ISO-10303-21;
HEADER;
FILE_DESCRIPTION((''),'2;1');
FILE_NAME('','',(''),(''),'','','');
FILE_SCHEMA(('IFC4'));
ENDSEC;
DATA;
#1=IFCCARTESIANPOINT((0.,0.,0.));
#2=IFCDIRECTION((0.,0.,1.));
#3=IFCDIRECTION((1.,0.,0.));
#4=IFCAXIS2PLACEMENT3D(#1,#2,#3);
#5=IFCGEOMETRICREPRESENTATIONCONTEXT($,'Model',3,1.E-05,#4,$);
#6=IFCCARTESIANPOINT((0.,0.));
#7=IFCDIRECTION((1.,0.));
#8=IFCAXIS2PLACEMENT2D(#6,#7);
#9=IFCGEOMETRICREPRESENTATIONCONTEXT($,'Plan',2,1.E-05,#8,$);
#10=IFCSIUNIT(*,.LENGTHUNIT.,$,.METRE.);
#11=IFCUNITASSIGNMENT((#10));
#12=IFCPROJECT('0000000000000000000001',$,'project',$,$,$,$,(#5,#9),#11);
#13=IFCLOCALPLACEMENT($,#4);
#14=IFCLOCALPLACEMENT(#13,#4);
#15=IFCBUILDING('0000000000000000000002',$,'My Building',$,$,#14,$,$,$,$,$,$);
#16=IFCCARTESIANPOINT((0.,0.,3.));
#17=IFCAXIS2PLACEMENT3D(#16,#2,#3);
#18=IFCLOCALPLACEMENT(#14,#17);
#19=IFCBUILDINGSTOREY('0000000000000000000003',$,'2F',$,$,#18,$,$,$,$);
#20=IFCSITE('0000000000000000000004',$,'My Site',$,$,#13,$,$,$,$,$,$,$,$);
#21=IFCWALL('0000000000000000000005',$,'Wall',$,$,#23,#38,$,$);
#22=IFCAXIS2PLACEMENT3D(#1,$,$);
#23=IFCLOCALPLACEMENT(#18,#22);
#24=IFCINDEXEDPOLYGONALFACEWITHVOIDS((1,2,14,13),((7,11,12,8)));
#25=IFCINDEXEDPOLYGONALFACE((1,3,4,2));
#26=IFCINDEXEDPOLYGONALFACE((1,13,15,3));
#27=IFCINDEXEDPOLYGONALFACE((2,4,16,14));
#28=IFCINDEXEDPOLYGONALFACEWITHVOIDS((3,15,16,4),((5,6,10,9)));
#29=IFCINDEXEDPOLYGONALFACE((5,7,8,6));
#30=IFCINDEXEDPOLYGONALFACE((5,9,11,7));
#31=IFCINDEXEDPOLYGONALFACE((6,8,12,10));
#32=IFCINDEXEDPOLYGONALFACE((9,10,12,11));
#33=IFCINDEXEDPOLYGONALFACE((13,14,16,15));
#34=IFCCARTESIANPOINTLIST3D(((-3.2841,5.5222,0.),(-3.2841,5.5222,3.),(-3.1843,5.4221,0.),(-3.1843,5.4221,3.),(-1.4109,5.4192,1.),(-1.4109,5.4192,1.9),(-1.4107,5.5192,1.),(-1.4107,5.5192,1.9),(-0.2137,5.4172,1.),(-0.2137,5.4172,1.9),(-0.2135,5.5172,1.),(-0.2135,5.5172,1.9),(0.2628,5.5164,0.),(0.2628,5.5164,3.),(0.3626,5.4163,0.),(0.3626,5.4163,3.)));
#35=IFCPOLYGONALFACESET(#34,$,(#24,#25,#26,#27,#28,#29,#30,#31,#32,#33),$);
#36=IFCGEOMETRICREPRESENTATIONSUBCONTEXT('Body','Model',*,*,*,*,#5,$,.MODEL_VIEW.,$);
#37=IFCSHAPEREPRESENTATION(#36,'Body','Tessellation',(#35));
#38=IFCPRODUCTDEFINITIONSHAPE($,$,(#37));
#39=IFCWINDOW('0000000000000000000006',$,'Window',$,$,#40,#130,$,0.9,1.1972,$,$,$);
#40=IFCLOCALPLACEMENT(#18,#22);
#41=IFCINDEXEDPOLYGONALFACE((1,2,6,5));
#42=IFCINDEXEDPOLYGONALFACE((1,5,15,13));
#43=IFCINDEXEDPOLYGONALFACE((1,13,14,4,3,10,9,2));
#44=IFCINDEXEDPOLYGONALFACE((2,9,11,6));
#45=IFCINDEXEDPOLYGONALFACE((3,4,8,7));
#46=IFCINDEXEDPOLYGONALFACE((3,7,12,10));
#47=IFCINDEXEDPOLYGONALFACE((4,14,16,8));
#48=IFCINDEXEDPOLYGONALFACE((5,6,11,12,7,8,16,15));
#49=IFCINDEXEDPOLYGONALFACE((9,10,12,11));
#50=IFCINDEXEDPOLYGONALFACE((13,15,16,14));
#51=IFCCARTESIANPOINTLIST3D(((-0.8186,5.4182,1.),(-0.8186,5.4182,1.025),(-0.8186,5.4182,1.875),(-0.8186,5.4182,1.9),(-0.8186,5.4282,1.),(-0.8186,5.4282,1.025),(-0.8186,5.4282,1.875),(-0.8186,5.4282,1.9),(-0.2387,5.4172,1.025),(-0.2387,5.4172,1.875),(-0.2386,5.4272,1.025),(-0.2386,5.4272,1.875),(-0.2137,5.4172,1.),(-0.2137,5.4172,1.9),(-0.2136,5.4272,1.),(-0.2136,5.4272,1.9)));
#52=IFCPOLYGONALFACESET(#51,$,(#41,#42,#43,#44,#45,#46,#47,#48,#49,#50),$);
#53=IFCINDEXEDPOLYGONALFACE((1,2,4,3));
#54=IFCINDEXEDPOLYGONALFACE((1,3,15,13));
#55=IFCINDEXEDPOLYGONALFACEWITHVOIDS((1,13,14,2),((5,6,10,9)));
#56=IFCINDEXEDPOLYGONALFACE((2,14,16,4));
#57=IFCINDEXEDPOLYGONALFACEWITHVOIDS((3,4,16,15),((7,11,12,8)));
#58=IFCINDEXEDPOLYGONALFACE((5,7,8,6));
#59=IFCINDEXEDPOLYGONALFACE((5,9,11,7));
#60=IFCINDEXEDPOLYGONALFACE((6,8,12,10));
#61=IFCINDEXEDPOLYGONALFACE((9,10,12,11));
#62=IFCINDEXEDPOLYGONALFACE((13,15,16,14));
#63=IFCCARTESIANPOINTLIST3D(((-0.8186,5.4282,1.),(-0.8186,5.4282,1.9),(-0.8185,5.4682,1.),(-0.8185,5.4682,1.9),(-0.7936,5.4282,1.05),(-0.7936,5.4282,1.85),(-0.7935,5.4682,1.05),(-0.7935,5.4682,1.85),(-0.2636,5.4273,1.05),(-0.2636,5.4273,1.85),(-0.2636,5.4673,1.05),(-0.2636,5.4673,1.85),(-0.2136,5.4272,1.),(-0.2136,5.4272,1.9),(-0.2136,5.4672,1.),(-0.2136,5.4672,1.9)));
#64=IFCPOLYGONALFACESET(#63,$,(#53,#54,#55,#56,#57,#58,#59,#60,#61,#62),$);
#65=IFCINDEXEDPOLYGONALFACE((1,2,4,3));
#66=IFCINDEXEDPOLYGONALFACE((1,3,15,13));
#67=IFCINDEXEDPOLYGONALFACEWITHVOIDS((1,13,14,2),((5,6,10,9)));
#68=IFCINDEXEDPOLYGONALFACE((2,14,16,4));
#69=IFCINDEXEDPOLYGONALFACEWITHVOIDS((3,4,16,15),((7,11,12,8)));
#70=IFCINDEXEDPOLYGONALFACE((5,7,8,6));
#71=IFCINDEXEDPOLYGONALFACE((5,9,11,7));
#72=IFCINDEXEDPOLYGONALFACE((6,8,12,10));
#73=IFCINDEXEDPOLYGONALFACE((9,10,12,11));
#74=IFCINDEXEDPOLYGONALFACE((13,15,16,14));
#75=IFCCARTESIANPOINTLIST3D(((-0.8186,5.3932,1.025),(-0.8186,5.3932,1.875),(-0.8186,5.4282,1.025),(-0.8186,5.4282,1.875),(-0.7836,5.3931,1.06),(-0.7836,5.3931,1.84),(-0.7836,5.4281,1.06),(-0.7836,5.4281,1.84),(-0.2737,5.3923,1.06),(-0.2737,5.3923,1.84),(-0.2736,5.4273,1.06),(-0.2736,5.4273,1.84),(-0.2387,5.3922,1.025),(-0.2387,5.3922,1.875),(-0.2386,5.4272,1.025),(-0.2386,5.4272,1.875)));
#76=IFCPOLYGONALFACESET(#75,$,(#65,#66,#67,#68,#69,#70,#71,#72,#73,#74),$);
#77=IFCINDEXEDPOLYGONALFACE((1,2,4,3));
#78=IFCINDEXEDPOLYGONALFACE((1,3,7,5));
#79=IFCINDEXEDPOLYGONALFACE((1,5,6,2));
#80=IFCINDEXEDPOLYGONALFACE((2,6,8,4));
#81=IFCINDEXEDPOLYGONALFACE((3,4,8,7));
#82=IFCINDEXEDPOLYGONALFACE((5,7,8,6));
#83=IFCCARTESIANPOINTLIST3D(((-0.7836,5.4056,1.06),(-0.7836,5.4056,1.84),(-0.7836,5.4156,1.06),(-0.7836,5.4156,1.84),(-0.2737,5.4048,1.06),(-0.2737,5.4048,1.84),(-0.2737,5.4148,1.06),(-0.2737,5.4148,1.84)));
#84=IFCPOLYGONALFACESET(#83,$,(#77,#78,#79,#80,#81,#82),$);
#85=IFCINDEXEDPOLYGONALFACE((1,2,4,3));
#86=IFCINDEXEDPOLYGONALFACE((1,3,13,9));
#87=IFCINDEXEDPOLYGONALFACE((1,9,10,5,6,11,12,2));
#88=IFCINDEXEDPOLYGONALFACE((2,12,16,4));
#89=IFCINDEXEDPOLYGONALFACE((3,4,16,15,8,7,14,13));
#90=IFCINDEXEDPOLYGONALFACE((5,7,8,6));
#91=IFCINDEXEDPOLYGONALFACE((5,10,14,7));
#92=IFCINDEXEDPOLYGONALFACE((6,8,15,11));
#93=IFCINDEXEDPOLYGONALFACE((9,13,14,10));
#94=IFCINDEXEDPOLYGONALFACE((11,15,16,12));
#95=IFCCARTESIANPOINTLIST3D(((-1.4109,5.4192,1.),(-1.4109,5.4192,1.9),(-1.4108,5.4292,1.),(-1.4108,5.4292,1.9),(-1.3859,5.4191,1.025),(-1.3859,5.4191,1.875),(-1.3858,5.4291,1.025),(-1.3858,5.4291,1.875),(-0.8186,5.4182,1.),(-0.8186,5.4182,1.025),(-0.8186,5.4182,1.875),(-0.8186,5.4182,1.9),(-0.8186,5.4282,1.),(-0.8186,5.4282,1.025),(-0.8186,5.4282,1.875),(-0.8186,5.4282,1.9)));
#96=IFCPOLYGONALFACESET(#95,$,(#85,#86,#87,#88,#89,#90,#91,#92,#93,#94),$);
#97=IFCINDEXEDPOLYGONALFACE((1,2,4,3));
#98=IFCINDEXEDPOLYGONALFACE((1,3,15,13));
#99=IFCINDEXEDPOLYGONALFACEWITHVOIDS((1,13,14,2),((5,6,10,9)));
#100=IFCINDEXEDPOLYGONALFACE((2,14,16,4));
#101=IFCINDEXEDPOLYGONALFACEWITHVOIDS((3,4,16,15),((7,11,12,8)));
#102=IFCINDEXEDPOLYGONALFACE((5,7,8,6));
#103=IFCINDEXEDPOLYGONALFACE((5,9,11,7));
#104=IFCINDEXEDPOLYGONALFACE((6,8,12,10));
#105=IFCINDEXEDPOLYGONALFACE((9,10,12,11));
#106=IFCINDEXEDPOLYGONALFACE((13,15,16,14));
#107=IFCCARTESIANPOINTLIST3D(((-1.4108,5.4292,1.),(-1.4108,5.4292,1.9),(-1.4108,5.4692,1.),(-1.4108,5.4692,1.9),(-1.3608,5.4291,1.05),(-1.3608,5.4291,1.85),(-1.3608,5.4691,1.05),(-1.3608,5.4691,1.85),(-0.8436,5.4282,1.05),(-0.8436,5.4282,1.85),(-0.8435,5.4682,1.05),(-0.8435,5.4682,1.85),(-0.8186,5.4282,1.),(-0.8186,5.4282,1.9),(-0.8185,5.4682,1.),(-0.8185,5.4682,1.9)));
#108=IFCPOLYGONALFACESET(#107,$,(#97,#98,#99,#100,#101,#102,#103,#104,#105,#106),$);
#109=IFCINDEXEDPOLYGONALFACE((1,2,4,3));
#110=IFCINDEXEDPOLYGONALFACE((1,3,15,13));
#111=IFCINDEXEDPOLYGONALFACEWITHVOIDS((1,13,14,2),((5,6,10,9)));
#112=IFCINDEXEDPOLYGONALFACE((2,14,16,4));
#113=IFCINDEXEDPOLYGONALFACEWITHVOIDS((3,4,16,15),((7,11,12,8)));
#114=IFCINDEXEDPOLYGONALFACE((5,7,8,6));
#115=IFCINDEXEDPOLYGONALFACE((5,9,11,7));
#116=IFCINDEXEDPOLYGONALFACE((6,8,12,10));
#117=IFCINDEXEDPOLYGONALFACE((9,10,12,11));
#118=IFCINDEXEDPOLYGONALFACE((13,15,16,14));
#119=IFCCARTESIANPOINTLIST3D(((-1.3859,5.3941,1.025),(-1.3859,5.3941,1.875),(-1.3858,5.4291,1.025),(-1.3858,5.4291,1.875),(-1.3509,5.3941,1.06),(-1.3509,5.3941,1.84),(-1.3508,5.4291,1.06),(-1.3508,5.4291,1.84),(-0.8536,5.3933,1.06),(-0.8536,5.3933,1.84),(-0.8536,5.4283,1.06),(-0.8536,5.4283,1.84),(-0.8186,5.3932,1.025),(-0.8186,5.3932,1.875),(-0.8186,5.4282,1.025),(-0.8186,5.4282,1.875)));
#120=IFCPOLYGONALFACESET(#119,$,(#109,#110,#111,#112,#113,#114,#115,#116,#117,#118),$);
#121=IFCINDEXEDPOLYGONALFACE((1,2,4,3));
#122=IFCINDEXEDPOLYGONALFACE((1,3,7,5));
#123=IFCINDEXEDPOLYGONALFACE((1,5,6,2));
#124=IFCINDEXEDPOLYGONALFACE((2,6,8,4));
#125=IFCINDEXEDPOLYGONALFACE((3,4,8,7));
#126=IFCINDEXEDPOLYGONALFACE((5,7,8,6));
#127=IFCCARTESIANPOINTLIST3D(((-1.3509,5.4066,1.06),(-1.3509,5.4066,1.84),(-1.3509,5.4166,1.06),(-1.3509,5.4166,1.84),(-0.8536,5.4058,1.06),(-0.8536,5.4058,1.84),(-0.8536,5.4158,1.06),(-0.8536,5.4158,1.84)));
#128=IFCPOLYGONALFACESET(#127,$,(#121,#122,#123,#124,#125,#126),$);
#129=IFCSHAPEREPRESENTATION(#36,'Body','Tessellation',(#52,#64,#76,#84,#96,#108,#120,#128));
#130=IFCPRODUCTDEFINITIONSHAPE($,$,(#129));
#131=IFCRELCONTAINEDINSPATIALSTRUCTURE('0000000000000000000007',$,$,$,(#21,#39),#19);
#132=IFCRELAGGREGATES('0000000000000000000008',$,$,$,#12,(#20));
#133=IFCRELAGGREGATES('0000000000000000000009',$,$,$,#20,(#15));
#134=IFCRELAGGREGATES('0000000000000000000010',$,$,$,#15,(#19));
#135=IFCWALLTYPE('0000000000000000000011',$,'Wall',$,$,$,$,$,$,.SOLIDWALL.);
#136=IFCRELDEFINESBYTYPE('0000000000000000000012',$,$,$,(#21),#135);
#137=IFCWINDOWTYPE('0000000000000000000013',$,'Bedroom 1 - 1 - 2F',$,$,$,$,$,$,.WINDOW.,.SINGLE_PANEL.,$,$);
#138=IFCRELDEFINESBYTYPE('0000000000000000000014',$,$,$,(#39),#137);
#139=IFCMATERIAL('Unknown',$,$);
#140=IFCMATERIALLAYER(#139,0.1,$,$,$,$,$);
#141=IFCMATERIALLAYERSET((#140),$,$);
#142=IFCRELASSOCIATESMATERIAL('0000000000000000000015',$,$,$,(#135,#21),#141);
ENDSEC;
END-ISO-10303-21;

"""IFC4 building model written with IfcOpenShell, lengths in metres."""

from ifc_helpers import new_model, entity, si_unit, frame, origin_with_axes, origin_2d_with_axis, place, context, subcontext, project, spatial, line, indexed_curve, outline, extrude, shape, source, transform, mapped, material, layer, layer_set, layer_usage, type_object, type_shapes, element, fill, save


model = new_model("IFC4")

# Units and contexts
model_context = context("Model", 3, precision=1e-05, world=origin_with_axes())
plan_context = context("Plan", 2, precision=1e-05, world=origin_2d_with_axis())
body_context_1 = subcontext(model_context, "Body", "Model", "MODEL_VIEW")
body_context_2 = subcontext(plan_context, "Body", "Plan", "PLAN_VIEW")
ifc_project = project(units=[si_unit("LENGTHUNIT", "METRE")], contexts=[model_context, plan_context])

# Site, building, storey
site_placement = place(None, origin_with_axes())
site = spatial("IfcSite", under=ifc_project, at=site_placement, Name="My Site")
building_placement = place(site_placement, origin_with_axes())
building = spatial("IfcBuilding", under=site, at=building_placement, Name="My Building")
storey_placement = place(building_placement, frame((0.0, 0.0, 3.0), z_axis=(0.0, 0.0, 1.0), x_axis=(1.0, 0.0, 0.0)))
storey = spatial("IfcBuildingStorey", under=building, at=storey_placement, Name="2F")

# Shared definitions
ifc_material = material(Name="Unknown")

# Shared definitions
ifc_layer = layer(ifc_material, 0.1)
ifc_layer_set = layer_set([ifc_layer])
wall_type = type_object("IfcWallType", Name="Wall", PredefinedType="SOLIDWALL", material=ifc_layer_set)

# Wall, opening, window
ifc_layer_usage_1 = layer_usage(ifc_layer_set, "AXIS2", "POSITIVE", 0.0)
wall_1_placement = place(storey_placement, frame((0.2628, 5.5164, 0.0), z_axis=(0.0, 0.0, 1.0), x_axis=(-0.999999, 0.001638, 0.0)))
wall_1 = element("IfcWall", 1, at=wall_1_placement, inside=storey, type_object=wall_type, material=ifc_layer_usage_1, Name="Wall", context=body_context_1, shape_type="SweptSolid", body=[
    extrude(outline(indexed_curve([(0.0, 0.0), (-0.1, 0.1), (3.4469, 0.1), (3.5469, 0.0)], segments=[line(1, 2, 3, 4, 1)])), origin_with_axes(), (0.0, 0.0, 1.0), 3.0),
])
shared_shape_1 = source(origin_with_axes(), body_context_1, "Body", "SweptSolid", [
    extrude(outline(indexed_curve([(0.0, 0.0), (1.1972, 0.0), (1.1972, 0.9), (0.0, 0.9)], segments=[line(1, 2, 3, 4, 1)])), frame((0.0, -0.6, 0.0), z_axis=(0.0, -1.0, 0.0), x_axis=(1.0, 0.0, 0.0)), (0.0, 0.0, -1.0), 1.2),
])
opening_1_placement = place(wall_1_placement, frame((0.4762, 0.0, 1.0), z_axis=(0.0, 0.0, 1.0), x_axis=(1.0, 0.0, 0.0)))
opening_1 = element("IfcOpeningElement", 2, at=opening_1_placement, cuts=wall_1, PredefinedType="OPENING", context=body_context_1, shape_type="MappedRepresentation", body=[
    mapped(shared_shape_1, transform((0.0, 0.0, 0.0), x_axis=(1.0, 0.0, 0.0), y_axis=(0.0, 1.0, 0.0), z_axis=(0.0, 0.0, 1.0), scale=1.0)),
])
window_type_1 = type_object("IfcWindowType", Name="Bedroom 1 - 1 - 2F", PartitioningType="SINGLE_PANEL", PredefinedType="WINDOW")
shared_shape_2 = source(origin_with_axes(), body_context_1, "Body", "SweptSolid", [
    extrude(outline(indexed_curve([(0.605, 0.0), (0.0, 0.0), (0.0, 0.9), (0.605, 0.9), (0.605, 0.875), (0.025, 0.875), (0.025, 0.025), (0.605, 0.025)], segments=[line(1, 2, 3, 4, 5, 6, 7, 8, 1)])), frame((0.0, 0.09, 0.0), z_axis=(0.0, -1.0, 0.0), x_axis=(1.0, 0.0, 0.0)), (0.0, 0.0, -1.0), 0.01),
    extrude(outline(indexed_curve([(0.0, 0.0), (0.605, 0.0), (0.605, 0.9), (0.0, 0.9)], segments=[line(1, 2, 3, 4, 1)]), holes=[indexed_curve([(0.05, 0.05), (0.58, 0.05), (0.58, 0.85), (0.05, 0.85)], segments=[line(1, 2, 3, 4, 1)])]), frame((0.0, 0.05, 0.0), z_axis=(0.0, -1.0, 0.0), x_axis=(1.0, 0.0, 0.0)), (0.0, 0.0, -1.0), 0.04),
    extrude(outline(indexed_curve([(0.0, 0.0), (0.58, 0.0), (0.58, 0.85), (0.0, 0.85)], segments=[line(1, 2, 3, 4, 1)]), holes=[indexed_curve([(0.035, 0.035), (0.545, 0.035), (0.545, 0.815), (0.035, 0.815)], segments=[line(1, 2, 3, 4, 1)])]), frame((0.025, 0.09, 0.025), z_axis=(0.0, -1.0, 0.0), x_axis=(1.0, 0.0, 0.0)), (0.0, 0.0, -1.0), 0.035),
    extrude(outline(indexed_curve([(0.035, 0.035), (0.545, 0.035), (0.545, 0.815), (0.035, 0.815)], segments=[line(1, 2, 3, 4, 1)])), frame((0.025, 0.1025, 0.025), z_axis=(0.0, -1.0, 0.0), x_axis=(1.0, 0.0, 0.0)), (0.0, 0.0, -1.0), 0.01),
    extrude(outline(indexed_curve([(0.0, 0.9), (0.5922, 0.9), (0.5922, 0.0), (0.0, 0.0), (0.0, 0.025), (0.5672, 0.025), (0.5672, 0.875), (0.0, 0.875)], segments=[line(1, 2, 3, 4, 5, 6, 7, 8, 1)])), frame((0.605, 0.09, 0.0), z_axis=(0.0, -1.0, 0.0), x_axis=(1.0, 0.0, 0.0)), (0.0, 0.0, -1.0), 0.01),
    extrude(outline(indexed_curve([(0.0, 0.0), (0.5922, 0.0), (0.5922, 0.9), (0.0, 0.9)], segments=[line(1, 2, 3, 4, 1)]), holes=[indexed_curve([(0.025, 0.05), (0.5422, 0.05), (0.5422, 0.85), (0.025, 0.85)], segments=[line(1, 2, 3, 4, 1)])]), frame((0.605, 0.05, 0.0), z_axis=(0.0, -1.0, 0.0), x_axis=(1.0, 0.0, 0.0)), (0.0, 0.0, -1.0), 0.04),
    extrude(outline(indexed_curve([(0.0, 0.0), (0.5672, 0.0), (0.5672, 0.85), (0.0, 0.85)], segments=[line(1, 2, 3, 4, 1)]), holes=[indexed_curve([(0.035, 0.035), (0.5322, 0.035), (0.5322, 0.815), (0.035, 0.815)], segments=[line(1, 2, 3, 4, 1)])]), frame((0.605, 0.09, 0.025), z_axis=(0.0, -1.0, 0.0), x_axis=(1.0, 0.0, 0.0)), (0.0, 0.0, -1.0), 0.035),
    extrude(outline(indexed_curve([(0.035, 0.035), (0.5322, 0.035), (0.5322, 0.815), (0.035, 0.815)], segments=[line(1, 2, 3, 4, 1)])), frame((0.605, 0.1025, 0.025), z_axis=(0.0, -1.0, 0.0), x_axis=(1.0, 0.0, 0.0)), (0.0, 0.0, -1.0), 0.01),
])
shared_shape_3 = source(origin_with_axes(), body_context_2, "Body", "Curve2D", [
    entity("IfcIndexedPolyCurve", entity("IfcCartesianPointList2D", [[0.05, 0.05], [0.58, 0.05]])),
    entity("IfcIndexedPolyCurve", entity("IfcCartesianPointList2D", [[0.0, 0.1], [0.025, 0.1], [0.025, 0.09], [0.05, 0.09], [0.05, 0.05], [0.0, 0.05]]), [entity("IfcLineIndex", [1, 2, 3, 4, 5, 6, 1])]),
    entity("IfcIndexedPolyCurve", entity("IfcCartesianPointList2D", [[0.605, 0.1], [0.605, 0.1], [0.605, 0.09], [0.58, 0.09], [0.58, 0.05], [0.605, 0.05]])),
    entity("IfcIndexedPolyCurve", entity("IfcCartesianPointList2D", [[0.025, 0.09], [0.06, 0.09], [0.06, 0.125], [0.025, 0.125]]), [entity("IfcLineIndex", [1, 2, 3, 4, 1])]),
    entity("IfcIndexedPolyCurve", entity("IfcCartesianPointList2D", [[0.605, 0.09], [0.57, 0.09], [0.57, 0.125], [0.605, 0.125]]), [entity("IfcLineIndex", [1, 2, 3, 4, 1])]),
    entity("IfcIndexedPolyCurve", entity("IfcCartesianPointList2D", [[0.06, 0.09], [0.57, 0.09]])),
    entity("IfcIndexedPolyCurve", entity("IfcCartesianPointList2D", [[0.06, 0.125], [0.57, 0.125]])),
    entity("IfcIndexedPolyCurve", entity("IfcCartesianPointList2D", [[0.06, 0.1075], [0.57, 0.1075]])),
    entity("IfcIndexedPolyCurve", entity("IfcCartesianPointList2D", [[0.63, 0.05], [1.1472, 0.05]])),
    entity("IfcIndexedPolyCurve", entity("IfcCartesianPointList2D", [[0.605, 0.1], [0.605, 0.1], [0.605, 0.09], [0.63, 0.09], [0.63, 0.05], [0.605, 0.05]])),
    entity("IfcIndexedPolyCurve", entity("IfcCartesianPointList2D", [[1.1972, 0.1], [1.1722, 0.1], [1.1722, 0.09], [1.1472, 0.09], [1.1472, 0.05], [1.1972, 0.05]]), [entity("IfcLineIndex", [1, 2, 3, 4, 5, 6, 1])]),
    entity("IfcIndexedPolyCurve", entity("IfcCartesianPointList2D", [[0.605, 0.09], [0.64, 0.09], [0.64, 0.125], [0.605, 0.125]]), [entity("IfcLineIndex", [1, 2, 3, 4, 1])]),
    entity("IfcIndexedPolyCurve", entity("IfcCartesianPointList2D", [[1.1722, 0.09], [1.1372, 0.09], [1.1372, 0.125], [1.1722, 0.125]]), [entity("IfcLineIndex", [1, 2, 3, 4, 1])]),
    entity("IfcIndexedPolyCurve", entity("IfcCartesianPointList2D", [[0.64, 0.09], [1.1372, 0.09]])),
    entity("IfcIndexedPolyCurve", entity("IfcCartesianPointList2D", [[0.64, 0.125], [1.1372, 0.125]])),
    entity("IfcIndexedPolyCurve", entity("IfcCartesianPointList2D", [[0.64, 0.1075], [1.1372, 0.1075]])),
])
type_shapes(window_type_1, [shared_shape_2, shared_shape_3])
window_1_placement = place(opening_1_placement, frame((0.0, 0.0, 0.0), z_axis=(0.0, 0.0, 1.0), x_axis=(1.0, 0.0, 0.0)))
window_1 = element("IfcWindow", 3, at=window_1_placement, inside=storey, type_object=window_type_1, Name="Window", OverallHeight=0.9, OverallWidth=1.1972, shapes=[
    shape(body_context_1, "Body", "MappedRepresentation", [mapped(shared_shape_2, transform((0.0, 0.0, 0.0), x_axis=(1.0, 0.0, 0.0), y_axis=(0.0, 1.0, 0.0), z_axis=(0.0, 0.0, 1.0), scale=1.0))]),
    shape(body_context_2, "Body", "MappedRepresentation", [mapped(shared_shape_3, transform((0.0, 0.0, 0.0), x_axis=(1.0, 0.0, 0.0), y_axis=(0.0, 1.0, 0.0), z_axis=(0.0, 0.0, 1.0), scale=1.0))]),
])
fill(opening_1, window_1)

save(model, "model.ifc")
